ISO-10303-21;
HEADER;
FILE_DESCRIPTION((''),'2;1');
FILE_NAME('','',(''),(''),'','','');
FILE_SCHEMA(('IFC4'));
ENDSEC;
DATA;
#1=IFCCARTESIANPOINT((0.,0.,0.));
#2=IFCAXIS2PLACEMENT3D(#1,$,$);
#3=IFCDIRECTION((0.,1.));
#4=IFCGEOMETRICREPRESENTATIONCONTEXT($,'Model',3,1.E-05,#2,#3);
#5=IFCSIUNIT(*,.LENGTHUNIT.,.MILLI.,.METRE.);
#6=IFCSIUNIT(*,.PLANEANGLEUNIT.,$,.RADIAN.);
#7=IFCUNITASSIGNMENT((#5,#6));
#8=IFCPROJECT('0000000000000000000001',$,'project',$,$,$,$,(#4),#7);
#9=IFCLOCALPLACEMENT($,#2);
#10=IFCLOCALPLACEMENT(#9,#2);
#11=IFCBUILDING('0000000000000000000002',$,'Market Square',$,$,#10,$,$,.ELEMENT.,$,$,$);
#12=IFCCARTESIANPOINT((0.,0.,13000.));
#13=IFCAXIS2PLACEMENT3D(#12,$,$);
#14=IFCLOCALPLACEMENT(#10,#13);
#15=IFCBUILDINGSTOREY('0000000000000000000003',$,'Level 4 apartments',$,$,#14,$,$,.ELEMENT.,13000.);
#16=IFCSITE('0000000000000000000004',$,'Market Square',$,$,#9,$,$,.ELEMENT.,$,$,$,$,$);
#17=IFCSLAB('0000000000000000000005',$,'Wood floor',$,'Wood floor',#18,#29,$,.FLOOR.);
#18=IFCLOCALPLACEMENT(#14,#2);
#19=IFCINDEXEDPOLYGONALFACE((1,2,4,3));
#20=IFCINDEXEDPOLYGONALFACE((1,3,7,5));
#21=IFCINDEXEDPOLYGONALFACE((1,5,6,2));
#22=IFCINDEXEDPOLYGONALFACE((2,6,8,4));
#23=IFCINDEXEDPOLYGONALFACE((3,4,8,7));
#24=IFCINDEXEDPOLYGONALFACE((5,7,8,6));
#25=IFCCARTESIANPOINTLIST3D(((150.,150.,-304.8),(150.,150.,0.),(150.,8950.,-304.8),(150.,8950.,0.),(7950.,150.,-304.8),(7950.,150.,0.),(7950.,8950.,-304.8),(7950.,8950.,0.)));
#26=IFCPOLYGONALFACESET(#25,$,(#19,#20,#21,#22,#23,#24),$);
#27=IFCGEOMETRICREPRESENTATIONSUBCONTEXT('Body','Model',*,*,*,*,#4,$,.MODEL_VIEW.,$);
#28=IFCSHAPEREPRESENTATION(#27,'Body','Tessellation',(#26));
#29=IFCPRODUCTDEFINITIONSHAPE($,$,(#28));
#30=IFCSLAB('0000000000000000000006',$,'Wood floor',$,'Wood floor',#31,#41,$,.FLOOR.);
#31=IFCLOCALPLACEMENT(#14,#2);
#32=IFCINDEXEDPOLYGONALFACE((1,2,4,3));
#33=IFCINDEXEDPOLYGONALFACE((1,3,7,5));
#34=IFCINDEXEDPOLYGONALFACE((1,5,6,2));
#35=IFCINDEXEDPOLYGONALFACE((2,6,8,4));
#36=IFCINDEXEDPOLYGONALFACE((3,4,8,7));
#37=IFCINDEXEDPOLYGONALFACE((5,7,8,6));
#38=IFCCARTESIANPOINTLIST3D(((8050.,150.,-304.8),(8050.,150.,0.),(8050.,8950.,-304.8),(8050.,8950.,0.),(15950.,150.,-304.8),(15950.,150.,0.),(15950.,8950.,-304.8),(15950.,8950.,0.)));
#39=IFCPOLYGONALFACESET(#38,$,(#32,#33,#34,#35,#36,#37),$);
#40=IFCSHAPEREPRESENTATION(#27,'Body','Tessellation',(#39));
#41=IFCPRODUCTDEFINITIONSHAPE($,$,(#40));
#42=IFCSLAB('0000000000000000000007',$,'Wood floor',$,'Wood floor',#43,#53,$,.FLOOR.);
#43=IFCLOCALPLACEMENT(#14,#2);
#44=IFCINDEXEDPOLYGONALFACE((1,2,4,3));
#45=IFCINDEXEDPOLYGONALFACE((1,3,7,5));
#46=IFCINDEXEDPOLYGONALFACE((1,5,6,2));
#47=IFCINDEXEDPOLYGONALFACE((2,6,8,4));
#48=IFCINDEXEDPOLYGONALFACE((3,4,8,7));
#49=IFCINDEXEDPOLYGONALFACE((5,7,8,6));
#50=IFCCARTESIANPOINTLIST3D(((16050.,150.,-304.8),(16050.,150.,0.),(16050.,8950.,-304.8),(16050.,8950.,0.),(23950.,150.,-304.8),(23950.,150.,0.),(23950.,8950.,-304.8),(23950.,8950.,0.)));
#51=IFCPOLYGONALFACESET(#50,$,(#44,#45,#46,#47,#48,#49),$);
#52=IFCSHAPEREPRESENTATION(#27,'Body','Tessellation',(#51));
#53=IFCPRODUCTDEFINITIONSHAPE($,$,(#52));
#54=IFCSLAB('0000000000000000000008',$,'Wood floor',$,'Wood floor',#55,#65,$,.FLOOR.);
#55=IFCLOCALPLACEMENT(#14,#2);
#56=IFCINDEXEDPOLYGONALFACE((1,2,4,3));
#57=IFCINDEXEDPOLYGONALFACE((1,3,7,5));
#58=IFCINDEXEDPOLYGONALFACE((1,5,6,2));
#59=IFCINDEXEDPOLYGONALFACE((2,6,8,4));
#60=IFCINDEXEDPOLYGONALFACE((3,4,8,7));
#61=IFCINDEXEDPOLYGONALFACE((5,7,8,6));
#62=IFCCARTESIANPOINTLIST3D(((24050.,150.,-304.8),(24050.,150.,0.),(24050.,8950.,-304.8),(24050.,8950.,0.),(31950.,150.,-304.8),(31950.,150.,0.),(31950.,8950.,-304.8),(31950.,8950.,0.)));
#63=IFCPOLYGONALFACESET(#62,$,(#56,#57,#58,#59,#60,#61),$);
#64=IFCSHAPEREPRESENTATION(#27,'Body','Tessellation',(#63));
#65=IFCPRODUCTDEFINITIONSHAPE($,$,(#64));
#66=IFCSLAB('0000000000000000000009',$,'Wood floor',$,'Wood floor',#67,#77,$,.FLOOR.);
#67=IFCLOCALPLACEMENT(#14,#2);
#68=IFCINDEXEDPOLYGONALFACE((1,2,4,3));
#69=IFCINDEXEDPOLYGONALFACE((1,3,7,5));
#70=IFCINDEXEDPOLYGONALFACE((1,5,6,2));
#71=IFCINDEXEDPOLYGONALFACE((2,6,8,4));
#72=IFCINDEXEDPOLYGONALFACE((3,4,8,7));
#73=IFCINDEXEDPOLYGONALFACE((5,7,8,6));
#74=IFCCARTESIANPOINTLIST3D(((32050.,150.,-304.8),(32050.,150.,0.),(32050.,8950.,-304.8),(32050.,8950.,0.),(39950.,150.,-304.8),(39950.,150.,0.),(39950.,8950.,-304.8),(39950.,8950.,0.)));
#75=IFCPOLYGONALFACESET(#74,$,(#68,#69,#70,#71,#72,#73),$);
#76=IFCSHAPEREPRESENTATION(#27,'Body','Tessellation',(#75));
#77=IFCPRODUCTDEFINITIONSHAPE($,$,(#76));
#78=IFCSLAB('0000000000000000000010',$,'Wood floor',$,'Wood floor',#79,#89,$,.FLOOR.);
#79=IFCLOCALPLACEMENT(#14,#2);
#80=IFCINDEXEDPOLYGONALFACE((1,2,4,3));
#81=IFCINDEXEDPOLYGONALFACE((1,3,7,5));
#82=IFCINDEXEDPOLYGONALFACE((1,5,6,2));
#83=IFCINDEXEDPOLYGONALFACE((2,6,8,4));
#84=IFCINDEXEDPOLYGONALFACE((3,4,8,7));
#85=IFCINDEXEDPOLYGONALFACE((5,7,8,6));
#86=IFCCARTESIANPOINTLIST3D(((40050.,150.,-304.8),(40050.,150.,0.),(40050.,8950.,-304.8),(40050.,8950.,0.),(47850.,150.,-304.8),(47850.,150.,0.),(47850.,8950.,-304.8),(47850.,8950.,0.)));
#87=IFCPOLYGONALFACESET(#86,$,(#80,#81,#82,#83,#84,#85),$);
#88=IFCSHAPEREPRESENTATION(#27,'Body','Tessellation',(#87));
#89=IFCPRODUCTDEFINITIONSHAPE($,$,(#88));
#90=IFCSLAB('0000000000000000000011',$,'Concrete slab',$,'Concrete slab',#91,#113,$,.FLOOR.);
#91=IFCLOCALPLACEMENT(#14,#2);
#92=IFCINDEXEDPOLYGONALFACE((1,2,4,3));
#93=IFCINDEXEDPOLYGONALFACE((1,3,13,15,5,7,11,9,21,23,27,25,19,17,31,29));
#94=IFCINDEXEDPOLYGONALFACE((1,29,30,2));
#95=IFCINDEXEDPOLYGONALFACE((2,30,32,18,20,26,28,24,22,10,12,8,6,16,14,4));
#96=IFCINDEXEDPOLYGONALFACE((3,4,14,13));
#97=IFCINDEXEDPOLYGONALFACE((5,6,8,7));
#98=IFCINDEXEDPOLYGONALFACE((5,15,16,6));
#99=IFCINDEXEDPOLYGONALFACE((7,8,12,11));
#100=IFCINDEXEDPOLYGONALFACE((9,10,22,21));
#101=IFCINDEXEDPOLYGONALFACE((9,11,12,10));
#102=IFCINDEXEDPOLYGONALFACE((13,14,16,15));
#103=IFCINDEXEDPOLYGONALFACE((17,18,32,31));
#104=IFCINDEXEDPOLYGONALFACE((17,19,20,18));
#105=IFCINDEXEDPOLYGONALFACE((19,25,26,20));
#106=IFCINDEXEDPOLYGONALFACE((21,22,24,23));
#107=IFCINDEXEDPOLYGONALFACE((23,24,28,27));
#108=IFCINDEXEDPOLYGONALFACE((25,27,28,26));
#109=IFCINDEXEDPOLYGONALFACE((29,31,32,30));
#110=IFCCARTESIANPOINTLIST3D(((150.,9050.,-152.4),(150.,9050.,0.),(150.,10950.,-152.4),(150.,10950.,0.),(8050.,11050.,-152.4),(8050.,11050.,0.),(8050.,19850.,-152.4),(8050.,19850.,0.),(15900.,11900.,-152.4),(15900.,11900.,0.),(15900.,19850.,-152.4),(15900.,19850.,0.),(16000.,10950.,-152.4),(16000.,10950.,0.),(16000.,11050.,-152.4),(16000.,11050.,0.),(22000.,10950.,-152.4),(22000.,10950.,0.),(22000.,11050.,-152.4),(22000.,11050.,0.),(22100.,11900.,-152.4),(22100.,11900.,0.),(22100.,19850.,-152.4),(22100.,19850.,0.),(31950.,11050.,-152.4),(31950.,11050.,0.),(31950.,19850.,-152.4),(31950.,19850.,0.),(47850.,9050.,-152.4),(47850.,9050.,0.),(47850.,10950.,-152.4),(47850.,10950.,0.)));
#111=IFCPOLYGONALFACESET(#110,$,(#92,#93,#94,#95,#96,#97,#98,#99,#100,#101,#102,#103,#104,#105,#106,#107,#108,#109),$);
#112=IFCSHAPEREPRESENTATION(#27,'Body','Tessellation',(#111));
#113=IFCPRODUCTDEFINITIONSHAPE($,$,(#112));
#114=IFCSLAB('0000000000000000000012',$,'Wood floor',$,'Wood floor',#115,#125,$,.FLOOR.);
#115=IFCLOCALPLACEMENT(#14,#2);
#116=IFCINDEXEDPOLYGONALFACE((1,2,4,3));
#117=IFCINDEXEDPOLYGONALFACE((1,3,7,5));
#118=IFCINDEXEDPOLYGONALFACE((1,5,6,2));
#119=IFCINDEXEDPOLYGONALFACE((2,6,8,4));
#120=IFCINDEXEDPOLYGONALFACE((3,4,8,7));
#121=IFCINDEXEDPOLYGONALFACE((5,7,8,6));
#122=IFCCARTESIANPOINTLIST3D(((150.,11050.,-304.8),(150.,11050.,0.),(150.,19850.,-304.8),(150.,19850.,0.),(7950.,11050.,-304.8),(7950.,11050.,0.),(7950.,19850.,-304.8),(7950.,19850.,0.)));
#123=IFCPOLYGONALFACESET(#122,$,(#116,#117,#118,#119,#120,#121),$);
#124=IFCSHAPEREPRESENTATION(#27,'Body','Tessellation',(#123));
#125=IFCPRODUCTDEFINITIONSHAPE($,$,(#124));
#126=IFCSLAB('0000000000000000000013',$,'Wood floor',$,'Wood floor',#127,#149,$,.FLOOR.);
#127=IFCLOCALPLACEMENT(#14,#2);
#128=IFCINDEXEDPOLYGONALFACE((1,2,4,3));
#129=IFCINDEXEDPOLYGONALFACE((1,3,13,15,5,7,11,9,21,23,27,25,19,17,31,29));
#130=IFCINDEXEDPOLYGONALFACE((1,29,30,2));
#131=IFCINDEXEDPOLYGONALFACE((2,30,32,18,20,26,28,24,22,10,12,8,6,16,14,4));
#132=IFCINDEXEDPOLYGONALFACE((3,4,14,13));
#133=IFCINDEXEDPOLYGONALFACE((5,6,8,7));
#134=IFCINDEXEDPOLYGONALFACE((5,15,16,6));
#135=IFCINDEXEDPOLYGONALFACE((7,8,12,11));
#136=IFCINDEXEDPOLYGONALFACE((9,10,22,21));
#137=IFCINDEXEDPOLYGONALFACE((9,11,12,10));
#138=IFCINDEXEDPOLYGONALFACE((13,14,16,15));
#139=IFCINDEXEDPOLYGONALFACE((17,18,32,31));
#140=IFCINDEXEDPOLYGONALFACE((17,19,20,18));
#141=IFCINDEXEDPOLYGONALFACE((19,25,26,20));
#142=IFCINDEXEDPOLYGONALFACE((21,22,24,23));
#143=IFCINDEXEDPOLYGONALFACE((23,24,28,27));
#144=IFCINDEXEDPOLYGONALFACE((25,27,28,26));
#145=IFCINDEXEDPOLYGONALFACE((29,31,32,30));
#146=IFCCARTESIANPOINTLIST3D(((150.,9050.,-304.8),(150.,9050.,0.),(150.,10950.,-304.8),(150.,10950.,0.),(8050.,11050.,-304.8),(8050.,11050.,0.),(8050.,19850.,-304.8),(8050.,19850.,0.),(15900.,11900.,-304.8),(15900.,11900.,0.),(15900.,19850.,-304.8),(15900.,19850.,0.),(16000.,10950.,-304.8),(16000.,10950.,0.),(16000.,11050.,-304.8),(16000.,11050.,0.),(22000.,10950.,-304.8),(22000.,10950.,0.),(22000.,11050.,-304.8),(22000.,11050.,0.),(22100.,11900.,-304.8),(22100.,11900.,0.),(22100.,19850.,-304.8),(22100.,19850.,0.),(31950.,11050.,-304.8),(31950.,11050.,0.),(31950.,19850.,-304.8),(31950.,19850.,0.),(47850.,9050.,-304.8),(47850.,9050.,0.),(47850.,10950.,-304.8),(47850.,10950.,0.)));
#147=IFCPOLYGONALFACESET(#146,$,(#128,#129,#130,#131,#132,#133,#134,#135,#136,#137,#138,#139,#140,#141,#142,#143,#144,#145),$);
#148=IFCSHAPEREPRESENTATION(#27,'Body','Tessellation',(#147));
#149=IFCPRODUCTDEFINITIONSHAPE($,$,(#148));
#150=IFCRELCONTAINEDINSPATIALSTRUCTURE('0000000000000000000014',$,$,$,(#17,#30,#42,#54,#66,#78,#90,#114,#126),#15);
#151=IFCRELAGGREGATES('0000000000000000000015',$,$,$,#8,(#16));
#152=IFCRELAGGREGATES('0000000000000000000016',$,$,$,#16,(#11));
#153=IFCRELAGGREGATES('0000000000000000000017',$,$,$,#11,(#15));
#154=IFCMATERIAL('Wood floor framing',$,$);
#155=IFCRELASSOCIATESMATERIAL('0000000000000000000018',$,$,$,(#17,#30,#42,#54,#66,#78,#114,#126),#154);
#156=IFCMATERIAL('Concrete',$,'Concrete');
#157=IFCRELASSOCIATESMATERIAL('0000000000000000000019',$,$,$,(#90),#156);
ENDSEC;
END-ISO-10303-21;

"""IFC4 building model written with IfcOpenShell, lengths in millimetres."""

from ifc_helpers import new_model, si_unit, direction, frame, origin, origin_with_axes, place, context, subcontext, project, spatial, polyline, outline, extrude, material, element, save


model = new_model("IFC4")

# Units and contexts
model_context = context("Model", 3, precision=1e-05, world=origin(), true_north=direction((0.0, 1.0)))
body_context = subcontext(model_context, "Body", "Model", "MODEL_VIEW")
ifc_project = project(units=[si_unit("LENGTHUNIT", "METRE", prefix="MILLI"), si_unit("PLANEANGLEUNIT", "RADIAN")], contexts=[model_context])

# Site, building, storey
site_placement = place(None, origin())
site = spatial("IfcSite", under=ifc_project, at=site_placement, Name="Market Square", CompositionType="ELEMENT")
building_placement = place(site_placement, origin())
building = spatial("IfcBuilding", under=site, at=building_placement, Name="Market Square", CompositionType="ELEMENT")
storey_placement = place(building_placement, frame((0.0, 0.0, 13000.0)))
storey = spatial("IfcBuildingStorey", under=building, at=storey_placement, Name="Level 4 apartments", CompositionType="ELEMENT", Elevation=13000.0)

# Slabs
ifc_material_1 = material(Name="Wood floor framing")
slab_1_placement = place(storey_placement, origin_with_axes())
element("IfcSlab", 1, at=slab_1_placement, inside=storey, material=ifc_material_1, Name="Wood floor", ObjectType="Wood floor", PredefinedType="FLOOR", context=body_context, shape_type="SweptSolid", body=[
    extrude(outline(polyline([(150.0, 150.0), (7950.0, 150.0), (7950.0, 8950.0), (150.0, 8950.0), (150.0, 150.0)])), frame((0.0, 0.0, -304.8)), (0.0, 0.0, 1.0), 304.8),
])
slab_2_placement = place(storey_placement, origin_with_axes())
element("IfcSlab", 2, at=slab_2_placement, inside=storey, material=ifc_material_1, Name="Wood floor", ObjectType="Wood floor", PredefinedType="FLOOR", context=body_context, shape_type="SweptSolid", body=[
    extrude(outline(polyline([(8050.0, 150.0), (15950.0, 150.0), (15950.0, 8950.0), (8050.0, 8950.0), (8050.0, 150.0)])), frame((0.0, 0.0, -304.8)), (0.0, 0.0, 1.0), 304.8),
])
slab_3_placement = place(storey_placement, origin_with_axes())
element("IfcSlab", 3, at=slab_3_placement, inside=storey, material=ifc_material_1, Name="Wood floor", ObjectType="Wood floor", PredefinedType="FLOOR", context=body_context, shape_type="SweptSolid", body=[
    extrude(outline(polyline([(16050.0, 150.0), (23950.0, 150.0), (23950.0, 8950.0), (16050.0, 8950.0), (16050.0, 150.0)])), frame((0.0, 0.0, -304.8)), (0.0, 0.0, 1.0), 304.8),
])
slab_4_placement = place(storey_placement, origin_with_axes())
element("IfcSlab", 4, at=slab_4_placement, inside=storey, material=ifc_material_1, Name="Wood floor", ObjectType="Wood floor", PredefinedType="FLOOR", context=body_context, shape_type="SweptSolid", body=[
    extrude(outline(polyline([(24050.0, 150.0), (31950.0, 150.0), (31950.0, 8950.0), (24050.0, 8950.0), (24050.0, 150.0)])), frame((0.0, 0.0, -304.8)), (0.0, 0.0, 1.0), 304.8),
])
slab_5_placement = place(storey_placement, origin_with_axes())
element("IfcSlab", 5, at=slab_5_placement, inside=storey, material=ifc_material_1, Name="Wood floor", ObjectType="Wood floor", PredefinedType="FLOOR", context=body_context, shape_type="SweptSolid", body=[
    extrude(outline(polyline([(32050.0, 150.0), (39950.0, 150.0), (39950.0, 8950.0), (32050.0, 8950.0), (32050.0, 150.0)])), frame((0.0, 0.0, -304.8)), (0.0, 0.0, 1.0), 304.8),
])
slab_6_placement = place(storey_placement, origin_with_axes())
element("IfcSlab", 6, at=slab_6_placement, inside=storey, material=ifc_material_1, Name="Wood floor", ObjectType="Wood floor", PredefinedType="FLOOR", context=body_context, shape_type="SweptSolid", body=[
    extrude(outline(polyline([(40050.0, 150.0), (47850.0, 150.0), (47850.0, 8950.0), (40050.0, 8950.0), (40050.0, 150.0)])), frame((0.0, 0.0, -304.8)), (0.0, 0.0, 1.0), 304.8),
])
ifc_material_2 = material(Name="Concrete", Category="Concrete")
slab_7_placement = place(storey_placement, origin_with_axes())
element("IfcSlab", 7, at=slab_7_placement, inside=storey, material=ifc_material_2, Name="Concrete slab", ObjectType="Concrete slab", PredefinedType="FLOOR", context=body_context, shape_type="SweptSolid", body=[
    extrude(outline(polyline([(47850.0, 9050.0), (47850.0, 10950.0), (22000.0, 10950.0), (22000.0, 11050.0), (31950.0, 11050.0), (31950.0, 19850.0), (22100.0, 19850.0), (22100.0, 11900.0), (15900.0, 11900.0), (15900.0, 19850.0), (8050.0, 19850.0), (8050.0, 11050.0), (16000.0, 11050.0), (16000.0, 10950.0), (150.0, 10950.0), (150.0, 9050.0), (47850.0, 9050.0)])), frame((0.0, 0.0, -152.4)), (0.0, 0.0, 1.0), 152.4),
])
slab_8_placement = place(storey_placement, origin_with_axes())
element("IfcSlab", 8, at=slab_8_placement, inside=storey, material=ifc_material_1, Name="Wood floor", ObjectType="Wood floor", PredefinedType="FLOOR", context=body_context, shape_type="SweptSolid", body=[
    extrude(outline(polyline([(7950.0, 19850.0), (150.0, 19850.0), (150.0, 11050.0), (7950.0, 11050.0), (7950.0, 19850.0)])), frame((0.0, 0.0, -304.8)), (0.0, 0.0, 1.0), 304.8),
])
for number, where, z_axis, x_axis, name in (
    (9, (0.0, 0.0, 0.0), (0.0, 0.0, 1.0), (1.0, 0.0, 0.0), "Wood floor"),
):
    element("IfcSlab", number, at=place(storey_placement, frame(where, z_axis=z_axis, x_axis=x_axis)), inside=storey, material=ifc_material_1, Name=name, ObjectType="Wood floor", PredefinedType="FLOOR", context=body_context, shape_type="SweptSolid", body=[
        extrude(outline(polyline([(47850.0, 9050.0), (47850.0, 10950.0), (22000.0, 10950.0), (22000.0, 11050.0), (31950.0, 11050.0), (31950.0, 19850.0), (22100.0, 19850.0), (22100.0, 11900.0), (15900.0, 11900.0), (15900.0, 19850.0), (8050.0, 19850.0), (8050.0, 11050.0), (16000.0, 11050.0), (16000.0, 10950.0), (150.0, 10950.0), (150.0, 9050.0), (47850.0, 9050.0)])), frame((0.0, 0.0, -304.8)), (0.0, 0.0, 1.0), 304.8),
    ])

save(model, "model.ifc")
